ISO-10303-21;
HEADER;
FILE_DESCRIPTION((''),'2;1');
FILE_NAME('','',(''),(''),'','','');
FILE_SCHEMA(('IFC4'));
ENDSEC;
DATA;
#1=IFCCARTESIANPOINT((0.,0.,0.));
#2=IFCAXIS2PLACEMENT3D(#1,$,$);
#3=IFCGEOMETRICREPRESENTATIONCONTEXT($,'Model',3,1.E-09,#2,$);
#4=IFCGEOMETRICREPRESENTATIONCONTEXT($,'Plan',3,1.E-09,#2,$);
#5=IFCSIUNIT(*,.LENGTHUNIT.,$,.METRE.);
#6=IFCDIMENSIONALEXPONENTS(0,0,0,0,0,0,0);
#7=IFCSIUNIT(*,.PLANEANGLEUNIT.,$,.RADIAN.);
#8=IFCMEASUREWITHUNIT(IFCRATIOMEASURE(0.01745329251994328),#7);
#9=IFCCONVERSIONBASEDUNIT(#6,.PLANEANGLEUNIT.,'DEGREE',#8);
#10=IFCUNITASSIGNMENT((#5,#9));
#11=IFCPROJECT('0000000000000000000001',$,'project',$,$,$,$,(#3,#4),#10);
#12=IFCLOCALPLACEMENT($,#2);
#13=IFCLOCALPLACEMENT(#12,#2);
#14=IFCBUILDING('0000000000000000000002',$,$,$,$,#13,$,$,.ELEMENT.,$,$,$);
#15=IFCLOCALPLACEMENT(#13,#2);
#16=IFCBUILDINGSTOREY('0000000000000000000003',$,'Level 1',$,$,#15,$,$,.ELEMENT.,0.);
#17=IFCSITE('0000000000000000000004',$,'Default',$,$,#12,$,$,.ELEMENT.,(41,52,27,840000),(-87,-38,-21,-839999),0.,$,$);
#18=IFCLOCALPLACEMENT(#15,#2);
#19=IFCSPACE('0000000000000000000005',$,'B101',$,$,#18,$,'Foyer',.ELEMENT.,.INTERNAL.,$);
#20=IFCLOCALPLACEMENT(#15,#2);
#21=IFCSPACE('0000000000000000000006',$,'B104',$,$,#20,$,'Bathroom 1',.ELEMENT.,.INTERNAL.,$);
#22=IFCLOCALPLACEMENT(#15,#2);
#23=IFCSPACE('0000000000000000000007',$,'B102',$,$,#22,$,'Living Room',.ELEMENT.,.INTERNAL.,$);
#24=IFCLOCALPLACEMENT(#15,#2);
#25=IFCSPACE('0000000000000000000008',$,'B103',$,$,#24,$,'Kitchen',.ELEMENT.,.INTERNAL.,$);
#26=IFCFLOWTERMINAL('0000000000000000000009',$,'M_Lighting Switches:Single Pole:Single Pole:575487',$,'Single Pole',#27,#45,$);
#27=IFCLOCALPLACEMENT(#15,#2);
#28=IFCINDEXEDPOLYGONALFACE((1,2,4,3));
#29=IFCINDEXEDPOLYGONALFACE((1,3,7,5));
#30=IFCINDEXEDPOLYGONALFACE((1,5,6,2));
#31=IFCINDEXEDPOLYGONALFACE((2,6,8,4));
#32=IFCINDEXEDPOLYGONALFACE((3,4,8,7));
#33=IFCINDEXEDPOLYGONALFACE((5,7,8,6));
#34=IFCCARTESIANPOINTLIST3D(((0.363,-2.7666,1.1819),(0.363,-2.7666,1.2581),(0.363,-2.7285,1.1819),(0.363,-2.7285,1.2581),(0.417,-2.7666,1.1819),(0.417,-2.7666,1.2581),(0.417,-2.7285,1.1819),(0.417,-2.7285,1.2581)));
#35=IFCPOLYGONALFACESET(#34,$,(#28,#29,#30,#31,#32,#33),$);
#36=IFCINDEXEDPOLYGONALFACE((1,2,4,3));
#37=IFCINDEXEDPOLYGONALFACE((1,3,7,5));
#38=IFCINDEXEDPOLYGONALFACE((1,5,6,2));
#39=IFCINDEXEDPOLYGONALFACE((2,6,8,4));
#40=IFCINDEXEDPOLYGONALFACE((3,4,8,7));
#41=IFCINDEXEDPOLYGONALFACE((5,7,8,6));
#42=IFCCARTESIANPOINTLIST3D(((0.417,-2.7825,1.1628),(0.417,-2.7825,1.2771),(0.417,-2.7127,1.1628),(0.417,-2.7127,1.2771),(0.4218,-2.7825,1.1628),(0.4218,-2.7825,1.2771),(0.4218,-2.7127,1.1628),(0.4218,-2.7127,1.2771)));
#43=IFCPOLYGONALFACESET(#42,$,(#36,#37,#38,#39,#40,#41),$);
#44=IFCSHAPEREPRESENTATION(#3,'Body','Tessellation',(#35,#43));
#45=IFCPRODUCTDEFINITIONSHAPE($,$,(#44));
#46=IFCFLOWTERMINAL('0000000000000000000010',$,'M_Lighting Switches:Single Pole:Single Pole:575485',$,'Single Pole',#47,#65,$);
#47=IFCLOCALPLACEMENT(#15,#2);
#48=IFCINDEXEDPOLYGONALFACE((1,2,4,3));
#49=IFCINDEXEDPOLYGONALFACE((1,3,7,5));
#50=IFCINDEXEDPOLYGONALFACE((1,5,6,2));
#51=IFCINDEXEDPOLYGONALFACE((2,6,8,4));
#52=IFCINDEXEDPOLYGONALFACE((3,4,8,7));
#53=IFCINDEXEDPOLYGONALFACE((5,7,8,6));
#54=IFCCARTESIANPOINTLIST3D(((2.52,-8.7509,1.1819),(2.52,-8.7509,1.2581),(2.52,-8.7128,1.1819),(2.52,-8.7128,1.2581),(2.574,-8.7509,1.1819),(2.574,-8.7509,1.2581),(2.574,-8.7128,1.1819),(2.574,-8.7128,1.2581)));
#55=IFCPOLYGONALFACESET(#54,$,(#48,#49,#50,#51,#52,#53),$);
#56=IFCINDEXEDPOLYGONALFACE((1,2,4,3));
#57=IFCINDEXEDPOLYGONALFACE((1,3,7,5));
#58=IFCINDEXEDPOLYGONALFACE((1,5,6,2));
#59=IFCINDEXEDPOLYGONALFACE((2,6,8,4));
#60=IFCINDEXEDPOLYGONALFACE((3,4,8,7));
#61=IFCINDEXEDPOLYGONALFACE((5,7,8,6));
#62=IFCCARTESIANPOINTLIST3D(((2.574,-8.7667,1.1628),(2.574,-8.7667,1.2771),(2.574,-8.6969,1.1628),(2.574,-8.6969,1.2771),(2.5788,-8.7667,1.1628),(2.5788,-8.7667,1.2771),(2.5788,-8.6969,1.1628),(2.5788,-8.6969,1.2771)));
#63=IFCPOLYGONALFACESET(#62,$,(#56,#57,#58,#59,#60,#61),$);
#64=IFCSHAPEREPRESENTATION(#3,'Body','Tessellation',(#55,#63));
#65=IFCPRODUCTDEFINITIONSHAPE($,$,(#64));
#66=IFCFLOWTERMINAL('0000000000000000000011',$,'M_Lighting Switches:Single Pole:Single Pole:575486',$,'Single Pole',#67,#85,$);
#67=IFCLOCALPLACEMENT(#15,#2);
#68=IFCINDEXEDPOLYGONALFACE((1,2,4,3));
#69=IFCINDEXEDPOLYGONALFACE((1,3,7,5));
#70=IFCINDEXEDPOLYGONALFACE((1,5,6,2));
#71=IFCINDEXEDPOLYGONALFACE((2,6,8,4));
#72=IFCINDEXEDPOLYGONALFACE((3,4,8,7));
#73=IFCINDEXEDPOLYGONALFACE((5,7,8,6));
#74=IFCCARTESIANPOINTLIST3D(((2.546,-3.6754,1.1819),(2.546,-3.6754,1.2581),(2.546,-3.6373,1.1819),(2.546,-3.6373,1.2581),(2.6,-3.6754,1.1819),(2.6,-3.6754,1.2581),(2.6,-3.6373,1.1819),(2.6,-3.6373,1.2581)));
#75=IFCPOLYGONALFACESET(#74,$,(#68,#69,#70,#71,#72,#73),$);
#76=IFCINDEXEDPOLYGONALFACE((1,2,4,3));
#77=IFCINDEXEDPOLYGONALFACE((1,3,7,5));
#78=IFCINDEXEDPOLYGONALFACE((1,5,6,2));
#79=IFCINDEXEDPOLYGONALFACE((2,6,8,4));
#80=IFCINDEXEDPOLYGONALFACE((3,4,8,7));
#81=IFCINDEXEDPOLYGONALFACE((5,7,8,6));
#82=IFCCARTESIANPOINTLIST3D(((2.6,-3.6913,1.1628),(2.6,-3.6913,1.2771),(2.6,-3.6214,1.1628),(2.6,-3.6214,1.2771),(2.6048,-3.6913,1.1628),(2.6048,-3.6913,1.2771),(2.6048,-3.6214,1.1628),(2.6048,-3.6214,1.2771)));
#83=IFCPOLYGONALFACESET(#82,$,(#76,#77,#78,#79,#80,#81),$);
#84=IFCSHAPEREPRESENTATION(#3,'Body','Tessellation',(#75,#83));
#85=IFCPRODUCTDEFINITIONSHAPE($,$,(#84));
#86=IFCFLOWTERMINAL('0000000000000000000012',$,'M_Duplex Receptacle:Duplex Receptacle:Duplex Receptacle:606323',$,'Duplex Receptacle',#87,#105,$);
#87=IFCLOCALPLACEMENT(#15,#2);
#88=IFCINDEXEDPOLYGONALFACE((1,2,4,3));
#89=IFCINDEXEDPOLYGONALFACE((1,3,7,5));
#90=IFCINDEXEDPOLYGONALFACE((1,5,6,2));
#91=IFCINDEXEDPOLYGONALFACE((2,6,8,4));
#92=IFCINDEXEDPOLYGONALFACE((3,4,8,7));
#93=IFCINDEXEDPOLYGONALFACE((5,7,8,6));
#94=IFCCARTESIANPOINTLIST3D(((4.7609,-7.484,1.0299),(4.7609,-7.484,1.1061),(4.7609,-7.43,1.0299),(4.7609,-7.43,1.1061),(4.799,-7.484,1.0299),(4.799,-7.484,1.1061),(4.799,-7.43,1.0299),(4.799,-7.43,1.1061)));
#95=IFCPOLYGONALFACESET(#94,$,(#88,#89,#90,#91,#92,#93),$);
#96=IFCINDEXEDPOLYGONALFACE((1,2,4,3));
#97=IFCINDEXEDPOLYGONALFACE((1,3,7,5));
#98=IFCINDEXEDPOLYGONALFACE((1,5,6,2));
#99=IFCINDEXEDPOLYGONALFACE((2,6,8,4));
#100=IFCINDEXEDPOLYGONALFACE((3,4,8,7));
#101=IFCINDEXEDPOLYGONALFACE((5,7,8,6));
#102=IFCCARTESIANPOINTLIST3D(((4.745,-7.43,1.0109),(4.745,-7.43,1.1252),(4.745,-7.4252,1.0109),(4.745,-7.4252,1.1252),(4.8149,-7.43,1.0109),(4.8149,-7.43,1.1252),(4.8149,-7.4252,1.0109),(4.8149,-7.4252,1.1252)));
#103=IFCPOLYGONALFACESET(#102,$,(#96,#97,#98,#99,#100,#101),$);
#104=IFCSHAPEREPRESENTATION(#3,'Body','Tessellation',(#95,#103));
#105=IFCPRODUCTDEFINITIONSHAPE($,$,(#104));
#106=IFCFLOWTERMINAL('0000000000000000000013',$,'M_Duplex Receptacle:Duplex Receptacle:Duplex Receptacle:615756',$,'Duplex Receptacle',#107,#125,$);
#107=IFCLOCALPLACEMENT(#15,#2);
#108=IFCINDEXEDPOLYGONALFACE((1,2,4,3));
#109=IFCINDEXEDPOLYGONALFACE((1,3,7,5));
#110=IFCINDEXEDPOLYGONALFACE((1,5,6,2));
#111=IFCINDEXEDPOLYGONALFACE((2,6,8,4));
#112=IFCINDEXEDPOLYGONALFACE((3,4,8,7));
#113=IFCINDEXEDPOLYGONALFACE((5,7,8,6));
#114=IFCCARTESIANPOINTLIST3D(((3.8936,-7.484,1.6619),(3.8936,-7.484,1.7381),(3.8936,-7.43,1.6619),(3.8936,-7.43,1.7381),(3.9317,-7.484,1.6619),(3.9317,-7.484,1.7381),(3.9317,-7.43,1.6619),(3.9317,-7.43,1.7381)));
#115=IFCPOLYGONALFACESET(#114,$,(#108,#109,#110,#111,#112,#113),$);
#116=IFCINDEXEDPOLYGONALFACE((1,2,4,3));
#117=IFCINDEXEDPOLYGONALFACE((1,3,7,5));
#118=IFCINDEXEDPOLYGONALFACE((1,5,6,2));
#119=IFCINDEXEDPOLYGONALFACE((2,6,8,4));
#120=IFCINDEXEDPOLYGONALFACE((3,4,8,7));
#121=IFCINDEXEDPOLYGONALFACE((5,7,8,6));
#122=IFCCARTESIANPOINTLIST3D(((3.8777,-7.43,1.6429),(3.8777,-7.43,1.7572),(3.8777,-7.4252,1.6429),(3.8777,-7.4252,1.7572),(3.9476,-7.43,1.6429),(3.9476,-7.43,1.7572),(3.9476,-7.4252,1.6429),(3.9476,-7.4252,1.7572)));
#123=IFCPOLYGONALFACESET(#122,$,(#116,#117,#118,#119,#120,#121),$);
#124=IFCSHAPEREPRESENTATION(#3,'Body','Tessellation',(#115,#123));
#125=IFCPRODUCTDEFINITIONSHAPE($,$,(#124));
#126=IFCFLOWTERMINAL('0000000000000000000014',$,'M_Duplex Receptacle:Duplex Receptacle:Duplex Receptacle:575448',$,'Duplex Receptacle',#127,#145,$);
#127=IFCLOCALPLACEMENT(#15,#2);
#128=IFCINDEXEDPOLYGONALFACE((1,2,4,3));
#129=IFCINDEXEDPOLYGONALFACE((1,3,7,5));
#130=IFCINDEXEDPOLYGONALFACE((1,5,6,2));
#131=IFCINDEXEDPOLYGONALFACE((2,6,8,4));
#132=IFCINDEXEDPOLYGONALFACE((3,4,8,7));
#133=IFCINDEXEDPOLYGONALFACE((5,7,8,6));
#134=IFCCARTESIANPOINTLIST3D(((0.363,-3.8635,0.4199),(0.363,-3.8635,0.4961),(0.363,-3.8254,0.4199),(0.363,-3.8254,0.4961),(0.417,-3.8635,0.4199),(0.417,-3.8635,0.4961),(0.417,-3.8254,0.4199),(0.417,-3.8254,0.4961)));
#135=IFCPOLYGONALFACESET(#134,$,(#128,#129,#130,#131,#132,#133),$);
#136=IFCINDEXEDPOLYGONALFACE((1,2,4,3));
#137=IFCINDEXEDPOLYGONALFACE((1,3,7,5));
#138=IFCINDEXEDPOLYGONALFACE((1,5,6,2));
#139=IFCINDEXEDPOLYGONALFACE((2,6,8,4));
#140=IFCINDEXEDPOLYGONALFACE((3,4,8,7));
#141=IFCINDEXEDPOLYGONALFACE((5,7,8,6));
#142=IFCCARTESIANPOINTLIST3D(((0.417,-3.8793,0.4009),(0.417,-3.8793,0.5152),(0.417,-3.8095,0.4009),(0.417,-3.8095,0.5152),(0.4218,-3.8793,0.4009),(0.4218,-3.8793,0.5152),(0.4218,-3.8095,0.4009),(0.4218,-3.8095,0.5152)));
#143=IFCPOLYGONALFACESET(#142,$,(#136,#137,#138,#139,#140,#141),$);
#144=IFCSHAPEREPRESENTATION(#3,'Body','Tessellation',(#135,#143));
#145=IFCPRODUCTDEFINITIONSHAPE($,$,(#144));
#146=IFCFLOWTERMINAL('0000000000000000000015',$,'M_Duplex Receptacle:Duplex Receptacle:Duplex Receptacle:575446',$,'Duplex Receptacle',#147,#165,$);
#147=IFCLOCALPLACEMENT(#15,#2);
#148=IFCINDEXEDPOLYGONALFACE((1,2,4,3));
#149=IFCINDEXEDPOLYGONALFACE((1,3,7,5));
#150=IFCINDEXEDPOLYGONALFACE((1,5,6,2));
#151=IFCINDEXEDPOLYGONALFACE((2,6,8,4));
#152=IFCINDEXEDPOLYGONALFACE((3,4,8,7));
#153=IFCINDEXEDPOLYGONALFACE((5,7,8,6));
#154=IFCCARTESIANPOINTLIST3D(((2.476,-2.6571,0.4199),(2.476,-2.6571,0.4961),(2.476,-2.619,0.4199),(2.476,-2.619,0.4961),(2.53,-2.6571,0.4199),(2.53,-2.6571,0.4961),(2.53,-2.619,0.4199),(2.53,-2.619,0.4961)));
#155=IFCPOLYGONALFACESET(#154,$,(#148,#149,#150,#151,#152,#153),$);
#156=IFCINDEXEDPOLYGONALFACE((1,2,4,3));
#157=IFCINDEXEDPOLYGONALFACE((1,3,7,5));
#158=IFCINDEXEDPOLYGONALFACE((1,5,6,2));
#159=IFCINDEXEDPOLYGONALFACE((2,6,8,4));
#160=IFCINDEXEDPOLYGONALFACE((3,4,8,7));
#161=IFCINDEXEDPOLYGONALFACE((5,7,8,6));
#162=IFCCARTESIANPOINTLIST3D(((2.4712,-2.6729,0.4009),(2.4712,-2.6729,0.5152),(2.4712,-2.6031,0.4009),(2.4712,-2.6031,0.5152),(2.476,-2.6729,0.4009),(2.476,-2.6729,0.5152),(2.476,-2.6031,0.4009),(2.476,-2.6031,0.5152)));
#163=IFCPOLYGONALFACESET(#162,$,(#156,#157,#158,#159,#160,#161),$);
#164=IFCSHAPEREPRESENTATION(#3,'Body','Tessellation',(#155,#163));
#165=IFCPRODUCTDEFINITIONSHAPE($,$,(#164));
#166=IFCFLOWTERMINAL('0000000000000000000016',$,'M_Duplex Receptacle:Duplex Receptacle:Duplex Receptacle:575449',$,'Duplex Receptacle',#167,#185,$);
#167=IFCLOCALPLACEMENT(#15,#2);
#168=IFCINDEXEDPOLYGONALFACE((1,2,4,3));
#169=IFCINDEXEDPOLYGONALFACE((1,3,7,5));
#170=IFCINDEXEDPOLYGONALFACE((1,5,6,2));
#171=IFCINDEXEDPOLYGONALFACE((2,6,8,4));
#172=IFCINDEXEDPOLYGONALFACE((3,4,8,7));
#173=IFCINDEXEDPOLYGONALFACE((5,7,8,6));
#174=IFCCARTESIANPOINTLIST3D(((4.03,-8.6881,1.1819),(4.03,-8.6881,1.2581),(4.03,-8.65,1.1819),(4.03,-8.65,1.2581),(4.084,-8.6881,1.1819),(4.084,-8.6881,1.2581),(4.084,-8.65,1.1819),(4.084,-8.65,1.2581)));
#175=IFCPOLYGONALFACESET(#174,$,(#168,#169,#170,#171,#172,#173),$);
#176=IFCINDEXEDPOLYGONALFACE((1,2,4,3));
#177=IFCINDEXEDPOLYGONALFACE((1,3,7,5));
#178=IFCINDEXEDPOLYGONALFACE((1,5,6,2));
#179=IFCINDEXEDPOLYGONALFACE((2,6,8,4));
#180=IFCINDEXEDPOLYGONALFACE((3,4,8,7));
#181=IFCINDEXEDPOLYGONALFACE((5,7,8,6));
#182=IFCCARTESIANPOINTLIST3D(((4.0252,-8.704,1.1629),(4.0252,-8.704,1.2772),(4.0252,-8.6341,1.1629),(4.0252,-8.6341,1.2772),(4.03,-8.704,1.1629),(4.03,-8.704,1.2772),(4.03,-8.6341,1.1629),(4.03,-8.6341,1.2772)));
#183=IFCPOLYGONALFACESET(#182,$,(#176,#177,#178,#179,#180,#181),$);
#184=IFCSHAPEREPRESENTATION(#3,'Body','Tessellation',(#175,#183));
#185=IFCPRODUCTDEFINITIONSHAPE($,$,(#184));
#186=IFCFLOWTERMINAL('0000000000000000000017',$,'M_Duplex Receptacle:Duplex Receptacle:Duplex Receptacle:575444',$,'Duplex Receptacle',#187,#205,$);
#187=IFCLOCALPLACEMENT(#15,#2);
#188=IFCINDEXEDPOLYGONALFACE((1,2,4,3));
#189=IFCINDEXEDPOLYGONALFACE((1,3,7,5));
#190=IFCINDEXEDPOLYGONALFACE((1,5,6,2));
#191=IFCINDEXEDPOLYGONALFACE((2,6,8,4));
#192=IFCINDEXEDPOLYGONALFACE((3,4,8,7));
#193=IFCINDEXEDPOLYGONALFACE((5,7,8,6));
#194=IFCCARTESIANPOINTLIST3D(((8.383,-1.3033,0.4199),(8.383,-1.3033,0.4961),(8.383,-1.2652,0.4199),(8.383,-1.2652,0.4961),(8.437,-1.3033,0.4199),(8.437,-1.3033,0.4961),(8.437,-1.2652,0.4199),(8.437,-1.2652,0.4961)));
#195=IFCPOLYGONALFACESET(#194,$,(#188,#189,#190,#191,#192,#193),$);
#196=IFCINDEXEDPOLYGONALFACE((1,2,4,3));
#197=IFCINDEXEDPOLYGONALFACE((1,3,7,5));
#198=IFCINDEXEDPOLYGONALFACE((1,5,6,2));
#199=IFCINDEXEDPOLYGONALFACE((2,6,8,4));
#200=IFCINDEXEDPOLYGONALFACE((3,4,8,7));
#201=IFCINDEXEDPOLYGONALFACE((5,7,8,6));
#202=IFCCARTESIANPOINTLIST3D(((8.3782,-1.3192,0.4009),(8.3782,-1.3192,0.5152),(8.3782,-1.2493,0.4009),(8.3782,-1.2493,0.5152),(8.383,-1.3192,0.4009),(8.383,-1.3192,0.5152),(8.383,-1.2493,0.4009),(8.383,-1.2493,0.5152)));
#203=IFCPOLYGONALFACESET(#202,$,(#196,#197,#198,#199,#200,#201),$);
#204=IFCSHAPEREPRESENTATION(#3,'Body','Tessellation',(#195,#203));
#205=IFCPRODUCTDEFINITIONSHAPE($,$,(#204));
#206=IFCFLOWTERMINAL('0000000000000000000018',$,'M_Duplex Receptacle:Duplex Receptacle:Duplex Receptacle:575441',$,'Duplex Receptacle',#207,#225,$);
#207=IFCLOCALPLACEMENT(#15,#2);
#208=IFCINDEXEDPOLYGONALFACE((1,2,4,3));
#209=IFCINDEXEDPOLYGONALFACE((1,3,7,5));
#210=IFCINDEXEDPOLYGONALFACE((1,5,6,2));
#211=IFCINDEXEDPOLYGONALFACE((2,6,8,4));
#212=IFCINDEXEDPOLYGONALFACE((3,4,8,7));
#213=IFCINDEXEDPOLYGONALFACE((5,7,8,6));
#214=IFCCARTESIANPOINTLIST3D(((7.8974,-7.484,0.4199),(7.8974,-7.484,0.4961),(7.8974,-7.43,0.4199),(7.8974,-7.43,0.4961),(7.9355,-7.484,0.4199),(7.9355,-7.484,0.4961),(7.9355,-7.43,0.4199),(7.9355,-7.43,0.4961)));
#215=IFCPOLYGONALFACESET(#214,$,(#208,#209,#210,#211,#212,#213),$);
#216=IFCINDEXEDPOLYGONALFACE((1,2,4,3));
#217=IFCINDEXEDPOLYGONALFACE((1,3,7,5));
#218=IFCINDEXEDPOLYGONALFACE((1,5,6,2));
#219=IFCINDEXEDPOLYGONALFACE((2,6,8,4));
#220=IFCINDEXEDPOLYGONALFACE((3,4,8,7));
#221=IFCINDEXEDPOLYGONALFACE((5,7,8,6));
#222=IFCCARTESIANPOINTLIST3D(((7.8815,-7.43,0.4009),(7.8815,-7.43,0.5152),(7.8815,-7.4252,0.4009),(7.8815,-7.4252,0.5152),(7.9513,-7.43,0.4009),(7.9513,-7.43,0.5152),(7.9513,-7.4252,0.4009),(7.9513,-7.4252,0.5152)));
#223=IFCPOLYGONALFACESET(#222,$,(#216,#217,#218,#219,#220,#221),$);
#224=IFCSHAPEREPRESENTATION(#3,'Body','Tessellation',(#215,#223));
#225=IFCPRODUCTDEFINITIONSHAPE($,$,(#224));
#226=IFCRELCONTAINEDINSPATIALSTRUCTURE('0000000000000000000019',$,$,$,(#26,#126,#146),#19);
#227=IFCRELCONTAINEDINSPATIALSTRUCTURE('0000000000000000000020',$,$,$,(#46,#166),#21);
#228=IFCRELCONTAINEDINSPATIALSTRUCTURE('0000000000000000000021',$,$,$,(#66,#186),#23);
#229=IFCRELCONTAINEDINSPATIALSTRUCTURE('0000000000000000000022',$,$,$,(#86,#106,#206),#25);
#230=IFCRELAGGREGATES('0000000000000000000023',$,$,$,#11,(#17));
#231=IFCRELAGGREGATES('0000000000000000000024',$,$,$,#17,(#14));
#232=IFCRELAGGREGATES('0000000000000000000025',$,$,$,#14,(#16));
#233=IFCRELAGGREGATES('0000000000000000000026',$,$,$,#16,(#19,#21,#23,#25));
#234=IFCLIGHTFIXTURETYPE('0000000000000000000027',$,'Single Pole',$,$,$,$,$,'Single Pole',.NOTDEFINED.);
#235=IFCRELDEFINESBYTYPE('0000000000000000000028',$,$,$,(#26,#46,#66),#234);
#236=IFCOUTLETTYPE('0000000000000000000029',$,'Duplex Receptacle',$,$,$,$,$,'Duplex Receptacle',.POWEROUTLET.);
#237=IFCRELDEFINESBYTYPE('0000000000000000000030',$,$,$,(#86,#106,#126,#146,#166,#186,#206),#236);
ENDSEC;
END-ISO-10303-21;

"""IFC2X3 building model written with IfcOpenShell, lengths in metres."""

from ifc_helpers import new_model, entity, si_unit, converted_unit, frame, origin, origin_2d_with_axis, place, context, project, spatial, rectangle, extrude, source, transform, mapped, type_object, type_shapes, element, save


model = new_model("IFC2X3")

# Units and contexts
model_context = context("Model", 3, precision=1e-09, world=origin())
plan_context = context("Plan", 3, precision=1e-09, world=origin())
ifc_project = project(units=[si_unit("LENGTHUNIT", "METRE"), converted_unit("PLANEANGLEUNIT", "DEGREE", entity("IfcRatioMeasure", 0.01745329251994328), si_unit("PLANEANGLEUNIT", "RADIAN"), dimensions=[0, 0, 0, 0, 0, 0, 0])], contexts=[model_context, plan_context])

# Site, building, storey, space
site_placement = place(None, origin())
site = spatial("IfcSite", under=ifc_project, at=site_placement, Name="Default", CompositionType="ELEMENT", RefLatitude=(41, 52, 27, 840000), RefLongitude=(-87, -38, -21, -839999), RefElevation=0.0)
building_placement = place(site_placement, origin())
building = spatial("IfcBuilding", under=site, at=building_placement, CompositionType="ELEMENT")
storey_placement = place(building_placement, origin())
storey = spatial("IfcBuildingStorey", under=building, at=storey_placement, Name="Level 1", CompositionType="ELEMENT", Elevation=0.0)
space_1_placement = place(storey_placement, origin())
space_1 = spatial("IfcSpace", under=storey, at=space_1_placement, Name="B101", LongName="Foyer", CompositionType="ELEMENT", InteriorOrExteriorSpace="INTERNAL")

# Flow terminal
light_fixture_type = type_object("IfcLightFixtureType", Name="Single Pole", ElementType="Single Pole", PredefinedType="NOTDEFINED")
shared_shape_1 = source(origin(), model_context, "Body", "SweptSolid", [
    extrude(rectangle(XDim=0.0381, YDim=0.0762, at=origin_2d_with_axis()), frame((0.0, 0.0, -0.054), z_axis=(0.0, 0.0, 1.0), x_axis=(-1.0, 0.0, 0.0)), (0.0, 0.0, 1.0), 0.054),
    extrude(rectangle(XDim=0.0698, YDim=0.1143, at=origin_2d_with_axis()), frame((0.0, 0.0, 0.0), z_axis=(0.0, 0.0, 1.0), x_axis=(-1.0, 0.0, 0.0)), (0.0, 0.0, 1.0), 0.0048),
])
type_shapes(light_fixture_type, [shared_shape_1])
flow_terminal_1_placement = place(space_1_placement, frame((0.417, -2.7476, 1.22), z_axis=(1.0, 0.0, 0.0), x_axis=(0.0, 1.0, 0.0)))
element("IfcFlowTerminal", 1, at=flow_terminal_1_placement, inside=space_1, type_object=light_fixture_type, Name="M_Lighting Switches:Single Pole:Single Pole:575487", ObjectType="Single Pole", context=model_context, shape_type="MappedRepresentation", body=[
    mapped(shared_shape_1, transform((0.0, 0.0, 0.0), scale=1.0)),
])

# Shared definitions
space_2_placement = place(storey_placement, origin())
space_2 = spatial("IfcSpace", under=storey, at=space_2_placement, Name="B104", LongName="Bathroom 1", CompositionType="ELEMENT", InteriorOrExteriorSpace="INTERNAL")

# Flow terminal
flow_terminal_2_placement = place(space_2_placement, frame((2.574, -8.7318, 1.22), z_axis=(1.0, 0.0, 0.0), x_axis=(0.0, 1.0, 0.0)))
element("IfcFlowTerminal", 2, at=flow_terminal_2_placement, inside=space_2, type_object=light_fixture_type, Name="M_Lighting Switches:Single Pole:Single Pole:575485", ObjectType="Single Pole", context=model_context, shape_type="MappedRepresentation", body=[
    mapped(shared_shape_1, transform((0.0, 0.0, 0.0), scale=1.0)),
])

# Shared definitions
space_3_placement = place(storey_placement, origin())
space_3 = spatial("IfcSpace", under=storey, at=space_3_placement, Name="B102", LongName="Living Room", CompositionType="ELEMENT", InteriorOrExteriorSpace="INTERNAL")

# Flow terminal
flow_terminal_3_placement = place(space_3_placement, frame((2.6, -3.6564, 1.22), z_axis=(1.0, 0.0, 0.0), x_axis=(0.0, 1.0, 0.0)))
element("IfcFlowTerminal", 3, at=flow_terminal_3_placement, inside=space_3, type_object=light_fixture_type, Name="M_Lighting Switches:Single Pole:Single Pole:575486", ObjectType="Single Pole", context=model_context, shape_type="MappedRepresentation", body=[
    mapped(shared_shape_1, transform((0.0, 0.0, 0.0), scale=1.0)),
])

# Shared definitions
space_4_placement = place(storey_placement, origin())
space_4 = spatial("IfcSpace", under=storey, at=space_4_placement, Name="B103", LongName="Kitchen", CompositionType="ELEMENT", InteriorOrExteriorSpace="INTERNAL")

# Flow terminals
outlet_type = type_object("IfcOutletType", Name="Duplex Receptacle", ElementType="Duplex Receptacle", PredefinedType="POWEROUTLET")
type_shapes(outlet_type, [shared_shape_1])
for number, where, z_axis, x_axis, name in (
    (4, (4.78, -7.43, 1.068), (0.0, 1.0, 0.0), (-1.0, 0.0, 0.0), "M_Duplex Receptacle:Duplex Receptacle:Duplex Receptacle:606323"),
    (5, (3.9127, -7.43, 1.7), (0.0, 1.0, 0.0), (-1.0, 0.0, 0.0), "M_Duplex Receptacle:Duplex Receptacle:Duplex Receptacle:615756"),
):
    element("IfcFlowTerminal", number, at=place(space_4_placement, frame(where, z_axis=z_axis, x_axis=x_axis)), inside=space_4, type_object=outlet_type, Name=name, ObjectType="Duplex Receptacle", context=model_context, shape_type="MappedRepresentation", body=[
        mapped(shared_shape_1, transform((0.0, 0.0, 0.0), scale=1.0)),
    ])
for number, where, z_axis, x_axis, name in (
    (6, (0.417, -3.8444, 0.458), (1.0, 0.0, 0.0), (0.0, 1.0, 0.0), "M_Duplex Receptacle:Duplex Receptacle:Duplex Receptacle:575448"),
    (7, (2.476, -2.638, 0.458), (-1.0, 0.0, 0.0), (0.0, -1.0, 0.0), "M_Duplex Receptacle:Duplex Receptacle:Duplex Receptacle:575446"),
):
    element("IfcFlowTerminal", number, at=place(space_1_placement, frame(where, z_axis=z_axis, x_axis=x_axis)), inside=space_1, type_object=outlet_type, Name=name, ObjectType="Duplex Receptacle", context=model_context, shape_type="MappedRepresentation", body=[
        mapped(shared_shape_1, transform((0.0, 0.0, 0.0), scale=1.0)),
    ])
flow_terminal_4_placement = place(space_2_placement, frame((4.03, -8.6691, 1.22), z_axis=(-1.0, 0.0, 0.0), x_axis=(0.0, -1.0, 0.0)))
element("IfcFlowTerminal", 8, at=flow_terminal_4_placement, inside=space_2, type_object=outlet_type, Name="M_Duplex Receptacle:Duplex Receptacle:Duplex Receptacle:575449", ObjectType="Duplex Receptacle", context=model_context, shape_type="MappedRepresentation", body=[
    mapped(shared_shape_1, transform((0.0, 0.0, 0.0), scale=1.0)),
])
flow_terminal_5_placement = place(space_3_placement, frame((8.383, -1.2842, 0.458), z_axis=(-1.0, 0.0, 0.0), x_axis=(0.0, -1.0, 0.0)))
element("IfcFlowTerminal", 9, at=flow_terminal_5_placement, inside=space_3, type_object=outlet_type, Name="M_Duplex Receptacle:Duplex Receptacle:Duplex Receptacle:575444", ObjectType="Duplex Receptacle", context=model_context, shape_type="MappedRepresentation", body=[
    mapped(shared_shape_1, transform((0.0, 0.0, 0.0), scale=1.0)),
])
flow_terminal_6_placement = place(space_4_placement, frame((7.9164, -7.43, 0.458), z_axis=(0.0, 1.0, 0.0), x_axis=(-1.0, 0.0, 0.0)))
element("IfcFlowTerminal", 10, at=flow_terminal_6_placement, inside=space_4, type_object=outlet_type, Name="M_Duplex Receptacle:Duplex Receptacle:Duplex Receptacle:575441", ObjectType="Duplex Receptacle", context=model_context, shape_type="MappedRepresentation", body=[
    mapped(shared_shape_1, transform((0.0, 0.0, 0.0), scale=1.0)),
])

save(model, "model.ifc")
